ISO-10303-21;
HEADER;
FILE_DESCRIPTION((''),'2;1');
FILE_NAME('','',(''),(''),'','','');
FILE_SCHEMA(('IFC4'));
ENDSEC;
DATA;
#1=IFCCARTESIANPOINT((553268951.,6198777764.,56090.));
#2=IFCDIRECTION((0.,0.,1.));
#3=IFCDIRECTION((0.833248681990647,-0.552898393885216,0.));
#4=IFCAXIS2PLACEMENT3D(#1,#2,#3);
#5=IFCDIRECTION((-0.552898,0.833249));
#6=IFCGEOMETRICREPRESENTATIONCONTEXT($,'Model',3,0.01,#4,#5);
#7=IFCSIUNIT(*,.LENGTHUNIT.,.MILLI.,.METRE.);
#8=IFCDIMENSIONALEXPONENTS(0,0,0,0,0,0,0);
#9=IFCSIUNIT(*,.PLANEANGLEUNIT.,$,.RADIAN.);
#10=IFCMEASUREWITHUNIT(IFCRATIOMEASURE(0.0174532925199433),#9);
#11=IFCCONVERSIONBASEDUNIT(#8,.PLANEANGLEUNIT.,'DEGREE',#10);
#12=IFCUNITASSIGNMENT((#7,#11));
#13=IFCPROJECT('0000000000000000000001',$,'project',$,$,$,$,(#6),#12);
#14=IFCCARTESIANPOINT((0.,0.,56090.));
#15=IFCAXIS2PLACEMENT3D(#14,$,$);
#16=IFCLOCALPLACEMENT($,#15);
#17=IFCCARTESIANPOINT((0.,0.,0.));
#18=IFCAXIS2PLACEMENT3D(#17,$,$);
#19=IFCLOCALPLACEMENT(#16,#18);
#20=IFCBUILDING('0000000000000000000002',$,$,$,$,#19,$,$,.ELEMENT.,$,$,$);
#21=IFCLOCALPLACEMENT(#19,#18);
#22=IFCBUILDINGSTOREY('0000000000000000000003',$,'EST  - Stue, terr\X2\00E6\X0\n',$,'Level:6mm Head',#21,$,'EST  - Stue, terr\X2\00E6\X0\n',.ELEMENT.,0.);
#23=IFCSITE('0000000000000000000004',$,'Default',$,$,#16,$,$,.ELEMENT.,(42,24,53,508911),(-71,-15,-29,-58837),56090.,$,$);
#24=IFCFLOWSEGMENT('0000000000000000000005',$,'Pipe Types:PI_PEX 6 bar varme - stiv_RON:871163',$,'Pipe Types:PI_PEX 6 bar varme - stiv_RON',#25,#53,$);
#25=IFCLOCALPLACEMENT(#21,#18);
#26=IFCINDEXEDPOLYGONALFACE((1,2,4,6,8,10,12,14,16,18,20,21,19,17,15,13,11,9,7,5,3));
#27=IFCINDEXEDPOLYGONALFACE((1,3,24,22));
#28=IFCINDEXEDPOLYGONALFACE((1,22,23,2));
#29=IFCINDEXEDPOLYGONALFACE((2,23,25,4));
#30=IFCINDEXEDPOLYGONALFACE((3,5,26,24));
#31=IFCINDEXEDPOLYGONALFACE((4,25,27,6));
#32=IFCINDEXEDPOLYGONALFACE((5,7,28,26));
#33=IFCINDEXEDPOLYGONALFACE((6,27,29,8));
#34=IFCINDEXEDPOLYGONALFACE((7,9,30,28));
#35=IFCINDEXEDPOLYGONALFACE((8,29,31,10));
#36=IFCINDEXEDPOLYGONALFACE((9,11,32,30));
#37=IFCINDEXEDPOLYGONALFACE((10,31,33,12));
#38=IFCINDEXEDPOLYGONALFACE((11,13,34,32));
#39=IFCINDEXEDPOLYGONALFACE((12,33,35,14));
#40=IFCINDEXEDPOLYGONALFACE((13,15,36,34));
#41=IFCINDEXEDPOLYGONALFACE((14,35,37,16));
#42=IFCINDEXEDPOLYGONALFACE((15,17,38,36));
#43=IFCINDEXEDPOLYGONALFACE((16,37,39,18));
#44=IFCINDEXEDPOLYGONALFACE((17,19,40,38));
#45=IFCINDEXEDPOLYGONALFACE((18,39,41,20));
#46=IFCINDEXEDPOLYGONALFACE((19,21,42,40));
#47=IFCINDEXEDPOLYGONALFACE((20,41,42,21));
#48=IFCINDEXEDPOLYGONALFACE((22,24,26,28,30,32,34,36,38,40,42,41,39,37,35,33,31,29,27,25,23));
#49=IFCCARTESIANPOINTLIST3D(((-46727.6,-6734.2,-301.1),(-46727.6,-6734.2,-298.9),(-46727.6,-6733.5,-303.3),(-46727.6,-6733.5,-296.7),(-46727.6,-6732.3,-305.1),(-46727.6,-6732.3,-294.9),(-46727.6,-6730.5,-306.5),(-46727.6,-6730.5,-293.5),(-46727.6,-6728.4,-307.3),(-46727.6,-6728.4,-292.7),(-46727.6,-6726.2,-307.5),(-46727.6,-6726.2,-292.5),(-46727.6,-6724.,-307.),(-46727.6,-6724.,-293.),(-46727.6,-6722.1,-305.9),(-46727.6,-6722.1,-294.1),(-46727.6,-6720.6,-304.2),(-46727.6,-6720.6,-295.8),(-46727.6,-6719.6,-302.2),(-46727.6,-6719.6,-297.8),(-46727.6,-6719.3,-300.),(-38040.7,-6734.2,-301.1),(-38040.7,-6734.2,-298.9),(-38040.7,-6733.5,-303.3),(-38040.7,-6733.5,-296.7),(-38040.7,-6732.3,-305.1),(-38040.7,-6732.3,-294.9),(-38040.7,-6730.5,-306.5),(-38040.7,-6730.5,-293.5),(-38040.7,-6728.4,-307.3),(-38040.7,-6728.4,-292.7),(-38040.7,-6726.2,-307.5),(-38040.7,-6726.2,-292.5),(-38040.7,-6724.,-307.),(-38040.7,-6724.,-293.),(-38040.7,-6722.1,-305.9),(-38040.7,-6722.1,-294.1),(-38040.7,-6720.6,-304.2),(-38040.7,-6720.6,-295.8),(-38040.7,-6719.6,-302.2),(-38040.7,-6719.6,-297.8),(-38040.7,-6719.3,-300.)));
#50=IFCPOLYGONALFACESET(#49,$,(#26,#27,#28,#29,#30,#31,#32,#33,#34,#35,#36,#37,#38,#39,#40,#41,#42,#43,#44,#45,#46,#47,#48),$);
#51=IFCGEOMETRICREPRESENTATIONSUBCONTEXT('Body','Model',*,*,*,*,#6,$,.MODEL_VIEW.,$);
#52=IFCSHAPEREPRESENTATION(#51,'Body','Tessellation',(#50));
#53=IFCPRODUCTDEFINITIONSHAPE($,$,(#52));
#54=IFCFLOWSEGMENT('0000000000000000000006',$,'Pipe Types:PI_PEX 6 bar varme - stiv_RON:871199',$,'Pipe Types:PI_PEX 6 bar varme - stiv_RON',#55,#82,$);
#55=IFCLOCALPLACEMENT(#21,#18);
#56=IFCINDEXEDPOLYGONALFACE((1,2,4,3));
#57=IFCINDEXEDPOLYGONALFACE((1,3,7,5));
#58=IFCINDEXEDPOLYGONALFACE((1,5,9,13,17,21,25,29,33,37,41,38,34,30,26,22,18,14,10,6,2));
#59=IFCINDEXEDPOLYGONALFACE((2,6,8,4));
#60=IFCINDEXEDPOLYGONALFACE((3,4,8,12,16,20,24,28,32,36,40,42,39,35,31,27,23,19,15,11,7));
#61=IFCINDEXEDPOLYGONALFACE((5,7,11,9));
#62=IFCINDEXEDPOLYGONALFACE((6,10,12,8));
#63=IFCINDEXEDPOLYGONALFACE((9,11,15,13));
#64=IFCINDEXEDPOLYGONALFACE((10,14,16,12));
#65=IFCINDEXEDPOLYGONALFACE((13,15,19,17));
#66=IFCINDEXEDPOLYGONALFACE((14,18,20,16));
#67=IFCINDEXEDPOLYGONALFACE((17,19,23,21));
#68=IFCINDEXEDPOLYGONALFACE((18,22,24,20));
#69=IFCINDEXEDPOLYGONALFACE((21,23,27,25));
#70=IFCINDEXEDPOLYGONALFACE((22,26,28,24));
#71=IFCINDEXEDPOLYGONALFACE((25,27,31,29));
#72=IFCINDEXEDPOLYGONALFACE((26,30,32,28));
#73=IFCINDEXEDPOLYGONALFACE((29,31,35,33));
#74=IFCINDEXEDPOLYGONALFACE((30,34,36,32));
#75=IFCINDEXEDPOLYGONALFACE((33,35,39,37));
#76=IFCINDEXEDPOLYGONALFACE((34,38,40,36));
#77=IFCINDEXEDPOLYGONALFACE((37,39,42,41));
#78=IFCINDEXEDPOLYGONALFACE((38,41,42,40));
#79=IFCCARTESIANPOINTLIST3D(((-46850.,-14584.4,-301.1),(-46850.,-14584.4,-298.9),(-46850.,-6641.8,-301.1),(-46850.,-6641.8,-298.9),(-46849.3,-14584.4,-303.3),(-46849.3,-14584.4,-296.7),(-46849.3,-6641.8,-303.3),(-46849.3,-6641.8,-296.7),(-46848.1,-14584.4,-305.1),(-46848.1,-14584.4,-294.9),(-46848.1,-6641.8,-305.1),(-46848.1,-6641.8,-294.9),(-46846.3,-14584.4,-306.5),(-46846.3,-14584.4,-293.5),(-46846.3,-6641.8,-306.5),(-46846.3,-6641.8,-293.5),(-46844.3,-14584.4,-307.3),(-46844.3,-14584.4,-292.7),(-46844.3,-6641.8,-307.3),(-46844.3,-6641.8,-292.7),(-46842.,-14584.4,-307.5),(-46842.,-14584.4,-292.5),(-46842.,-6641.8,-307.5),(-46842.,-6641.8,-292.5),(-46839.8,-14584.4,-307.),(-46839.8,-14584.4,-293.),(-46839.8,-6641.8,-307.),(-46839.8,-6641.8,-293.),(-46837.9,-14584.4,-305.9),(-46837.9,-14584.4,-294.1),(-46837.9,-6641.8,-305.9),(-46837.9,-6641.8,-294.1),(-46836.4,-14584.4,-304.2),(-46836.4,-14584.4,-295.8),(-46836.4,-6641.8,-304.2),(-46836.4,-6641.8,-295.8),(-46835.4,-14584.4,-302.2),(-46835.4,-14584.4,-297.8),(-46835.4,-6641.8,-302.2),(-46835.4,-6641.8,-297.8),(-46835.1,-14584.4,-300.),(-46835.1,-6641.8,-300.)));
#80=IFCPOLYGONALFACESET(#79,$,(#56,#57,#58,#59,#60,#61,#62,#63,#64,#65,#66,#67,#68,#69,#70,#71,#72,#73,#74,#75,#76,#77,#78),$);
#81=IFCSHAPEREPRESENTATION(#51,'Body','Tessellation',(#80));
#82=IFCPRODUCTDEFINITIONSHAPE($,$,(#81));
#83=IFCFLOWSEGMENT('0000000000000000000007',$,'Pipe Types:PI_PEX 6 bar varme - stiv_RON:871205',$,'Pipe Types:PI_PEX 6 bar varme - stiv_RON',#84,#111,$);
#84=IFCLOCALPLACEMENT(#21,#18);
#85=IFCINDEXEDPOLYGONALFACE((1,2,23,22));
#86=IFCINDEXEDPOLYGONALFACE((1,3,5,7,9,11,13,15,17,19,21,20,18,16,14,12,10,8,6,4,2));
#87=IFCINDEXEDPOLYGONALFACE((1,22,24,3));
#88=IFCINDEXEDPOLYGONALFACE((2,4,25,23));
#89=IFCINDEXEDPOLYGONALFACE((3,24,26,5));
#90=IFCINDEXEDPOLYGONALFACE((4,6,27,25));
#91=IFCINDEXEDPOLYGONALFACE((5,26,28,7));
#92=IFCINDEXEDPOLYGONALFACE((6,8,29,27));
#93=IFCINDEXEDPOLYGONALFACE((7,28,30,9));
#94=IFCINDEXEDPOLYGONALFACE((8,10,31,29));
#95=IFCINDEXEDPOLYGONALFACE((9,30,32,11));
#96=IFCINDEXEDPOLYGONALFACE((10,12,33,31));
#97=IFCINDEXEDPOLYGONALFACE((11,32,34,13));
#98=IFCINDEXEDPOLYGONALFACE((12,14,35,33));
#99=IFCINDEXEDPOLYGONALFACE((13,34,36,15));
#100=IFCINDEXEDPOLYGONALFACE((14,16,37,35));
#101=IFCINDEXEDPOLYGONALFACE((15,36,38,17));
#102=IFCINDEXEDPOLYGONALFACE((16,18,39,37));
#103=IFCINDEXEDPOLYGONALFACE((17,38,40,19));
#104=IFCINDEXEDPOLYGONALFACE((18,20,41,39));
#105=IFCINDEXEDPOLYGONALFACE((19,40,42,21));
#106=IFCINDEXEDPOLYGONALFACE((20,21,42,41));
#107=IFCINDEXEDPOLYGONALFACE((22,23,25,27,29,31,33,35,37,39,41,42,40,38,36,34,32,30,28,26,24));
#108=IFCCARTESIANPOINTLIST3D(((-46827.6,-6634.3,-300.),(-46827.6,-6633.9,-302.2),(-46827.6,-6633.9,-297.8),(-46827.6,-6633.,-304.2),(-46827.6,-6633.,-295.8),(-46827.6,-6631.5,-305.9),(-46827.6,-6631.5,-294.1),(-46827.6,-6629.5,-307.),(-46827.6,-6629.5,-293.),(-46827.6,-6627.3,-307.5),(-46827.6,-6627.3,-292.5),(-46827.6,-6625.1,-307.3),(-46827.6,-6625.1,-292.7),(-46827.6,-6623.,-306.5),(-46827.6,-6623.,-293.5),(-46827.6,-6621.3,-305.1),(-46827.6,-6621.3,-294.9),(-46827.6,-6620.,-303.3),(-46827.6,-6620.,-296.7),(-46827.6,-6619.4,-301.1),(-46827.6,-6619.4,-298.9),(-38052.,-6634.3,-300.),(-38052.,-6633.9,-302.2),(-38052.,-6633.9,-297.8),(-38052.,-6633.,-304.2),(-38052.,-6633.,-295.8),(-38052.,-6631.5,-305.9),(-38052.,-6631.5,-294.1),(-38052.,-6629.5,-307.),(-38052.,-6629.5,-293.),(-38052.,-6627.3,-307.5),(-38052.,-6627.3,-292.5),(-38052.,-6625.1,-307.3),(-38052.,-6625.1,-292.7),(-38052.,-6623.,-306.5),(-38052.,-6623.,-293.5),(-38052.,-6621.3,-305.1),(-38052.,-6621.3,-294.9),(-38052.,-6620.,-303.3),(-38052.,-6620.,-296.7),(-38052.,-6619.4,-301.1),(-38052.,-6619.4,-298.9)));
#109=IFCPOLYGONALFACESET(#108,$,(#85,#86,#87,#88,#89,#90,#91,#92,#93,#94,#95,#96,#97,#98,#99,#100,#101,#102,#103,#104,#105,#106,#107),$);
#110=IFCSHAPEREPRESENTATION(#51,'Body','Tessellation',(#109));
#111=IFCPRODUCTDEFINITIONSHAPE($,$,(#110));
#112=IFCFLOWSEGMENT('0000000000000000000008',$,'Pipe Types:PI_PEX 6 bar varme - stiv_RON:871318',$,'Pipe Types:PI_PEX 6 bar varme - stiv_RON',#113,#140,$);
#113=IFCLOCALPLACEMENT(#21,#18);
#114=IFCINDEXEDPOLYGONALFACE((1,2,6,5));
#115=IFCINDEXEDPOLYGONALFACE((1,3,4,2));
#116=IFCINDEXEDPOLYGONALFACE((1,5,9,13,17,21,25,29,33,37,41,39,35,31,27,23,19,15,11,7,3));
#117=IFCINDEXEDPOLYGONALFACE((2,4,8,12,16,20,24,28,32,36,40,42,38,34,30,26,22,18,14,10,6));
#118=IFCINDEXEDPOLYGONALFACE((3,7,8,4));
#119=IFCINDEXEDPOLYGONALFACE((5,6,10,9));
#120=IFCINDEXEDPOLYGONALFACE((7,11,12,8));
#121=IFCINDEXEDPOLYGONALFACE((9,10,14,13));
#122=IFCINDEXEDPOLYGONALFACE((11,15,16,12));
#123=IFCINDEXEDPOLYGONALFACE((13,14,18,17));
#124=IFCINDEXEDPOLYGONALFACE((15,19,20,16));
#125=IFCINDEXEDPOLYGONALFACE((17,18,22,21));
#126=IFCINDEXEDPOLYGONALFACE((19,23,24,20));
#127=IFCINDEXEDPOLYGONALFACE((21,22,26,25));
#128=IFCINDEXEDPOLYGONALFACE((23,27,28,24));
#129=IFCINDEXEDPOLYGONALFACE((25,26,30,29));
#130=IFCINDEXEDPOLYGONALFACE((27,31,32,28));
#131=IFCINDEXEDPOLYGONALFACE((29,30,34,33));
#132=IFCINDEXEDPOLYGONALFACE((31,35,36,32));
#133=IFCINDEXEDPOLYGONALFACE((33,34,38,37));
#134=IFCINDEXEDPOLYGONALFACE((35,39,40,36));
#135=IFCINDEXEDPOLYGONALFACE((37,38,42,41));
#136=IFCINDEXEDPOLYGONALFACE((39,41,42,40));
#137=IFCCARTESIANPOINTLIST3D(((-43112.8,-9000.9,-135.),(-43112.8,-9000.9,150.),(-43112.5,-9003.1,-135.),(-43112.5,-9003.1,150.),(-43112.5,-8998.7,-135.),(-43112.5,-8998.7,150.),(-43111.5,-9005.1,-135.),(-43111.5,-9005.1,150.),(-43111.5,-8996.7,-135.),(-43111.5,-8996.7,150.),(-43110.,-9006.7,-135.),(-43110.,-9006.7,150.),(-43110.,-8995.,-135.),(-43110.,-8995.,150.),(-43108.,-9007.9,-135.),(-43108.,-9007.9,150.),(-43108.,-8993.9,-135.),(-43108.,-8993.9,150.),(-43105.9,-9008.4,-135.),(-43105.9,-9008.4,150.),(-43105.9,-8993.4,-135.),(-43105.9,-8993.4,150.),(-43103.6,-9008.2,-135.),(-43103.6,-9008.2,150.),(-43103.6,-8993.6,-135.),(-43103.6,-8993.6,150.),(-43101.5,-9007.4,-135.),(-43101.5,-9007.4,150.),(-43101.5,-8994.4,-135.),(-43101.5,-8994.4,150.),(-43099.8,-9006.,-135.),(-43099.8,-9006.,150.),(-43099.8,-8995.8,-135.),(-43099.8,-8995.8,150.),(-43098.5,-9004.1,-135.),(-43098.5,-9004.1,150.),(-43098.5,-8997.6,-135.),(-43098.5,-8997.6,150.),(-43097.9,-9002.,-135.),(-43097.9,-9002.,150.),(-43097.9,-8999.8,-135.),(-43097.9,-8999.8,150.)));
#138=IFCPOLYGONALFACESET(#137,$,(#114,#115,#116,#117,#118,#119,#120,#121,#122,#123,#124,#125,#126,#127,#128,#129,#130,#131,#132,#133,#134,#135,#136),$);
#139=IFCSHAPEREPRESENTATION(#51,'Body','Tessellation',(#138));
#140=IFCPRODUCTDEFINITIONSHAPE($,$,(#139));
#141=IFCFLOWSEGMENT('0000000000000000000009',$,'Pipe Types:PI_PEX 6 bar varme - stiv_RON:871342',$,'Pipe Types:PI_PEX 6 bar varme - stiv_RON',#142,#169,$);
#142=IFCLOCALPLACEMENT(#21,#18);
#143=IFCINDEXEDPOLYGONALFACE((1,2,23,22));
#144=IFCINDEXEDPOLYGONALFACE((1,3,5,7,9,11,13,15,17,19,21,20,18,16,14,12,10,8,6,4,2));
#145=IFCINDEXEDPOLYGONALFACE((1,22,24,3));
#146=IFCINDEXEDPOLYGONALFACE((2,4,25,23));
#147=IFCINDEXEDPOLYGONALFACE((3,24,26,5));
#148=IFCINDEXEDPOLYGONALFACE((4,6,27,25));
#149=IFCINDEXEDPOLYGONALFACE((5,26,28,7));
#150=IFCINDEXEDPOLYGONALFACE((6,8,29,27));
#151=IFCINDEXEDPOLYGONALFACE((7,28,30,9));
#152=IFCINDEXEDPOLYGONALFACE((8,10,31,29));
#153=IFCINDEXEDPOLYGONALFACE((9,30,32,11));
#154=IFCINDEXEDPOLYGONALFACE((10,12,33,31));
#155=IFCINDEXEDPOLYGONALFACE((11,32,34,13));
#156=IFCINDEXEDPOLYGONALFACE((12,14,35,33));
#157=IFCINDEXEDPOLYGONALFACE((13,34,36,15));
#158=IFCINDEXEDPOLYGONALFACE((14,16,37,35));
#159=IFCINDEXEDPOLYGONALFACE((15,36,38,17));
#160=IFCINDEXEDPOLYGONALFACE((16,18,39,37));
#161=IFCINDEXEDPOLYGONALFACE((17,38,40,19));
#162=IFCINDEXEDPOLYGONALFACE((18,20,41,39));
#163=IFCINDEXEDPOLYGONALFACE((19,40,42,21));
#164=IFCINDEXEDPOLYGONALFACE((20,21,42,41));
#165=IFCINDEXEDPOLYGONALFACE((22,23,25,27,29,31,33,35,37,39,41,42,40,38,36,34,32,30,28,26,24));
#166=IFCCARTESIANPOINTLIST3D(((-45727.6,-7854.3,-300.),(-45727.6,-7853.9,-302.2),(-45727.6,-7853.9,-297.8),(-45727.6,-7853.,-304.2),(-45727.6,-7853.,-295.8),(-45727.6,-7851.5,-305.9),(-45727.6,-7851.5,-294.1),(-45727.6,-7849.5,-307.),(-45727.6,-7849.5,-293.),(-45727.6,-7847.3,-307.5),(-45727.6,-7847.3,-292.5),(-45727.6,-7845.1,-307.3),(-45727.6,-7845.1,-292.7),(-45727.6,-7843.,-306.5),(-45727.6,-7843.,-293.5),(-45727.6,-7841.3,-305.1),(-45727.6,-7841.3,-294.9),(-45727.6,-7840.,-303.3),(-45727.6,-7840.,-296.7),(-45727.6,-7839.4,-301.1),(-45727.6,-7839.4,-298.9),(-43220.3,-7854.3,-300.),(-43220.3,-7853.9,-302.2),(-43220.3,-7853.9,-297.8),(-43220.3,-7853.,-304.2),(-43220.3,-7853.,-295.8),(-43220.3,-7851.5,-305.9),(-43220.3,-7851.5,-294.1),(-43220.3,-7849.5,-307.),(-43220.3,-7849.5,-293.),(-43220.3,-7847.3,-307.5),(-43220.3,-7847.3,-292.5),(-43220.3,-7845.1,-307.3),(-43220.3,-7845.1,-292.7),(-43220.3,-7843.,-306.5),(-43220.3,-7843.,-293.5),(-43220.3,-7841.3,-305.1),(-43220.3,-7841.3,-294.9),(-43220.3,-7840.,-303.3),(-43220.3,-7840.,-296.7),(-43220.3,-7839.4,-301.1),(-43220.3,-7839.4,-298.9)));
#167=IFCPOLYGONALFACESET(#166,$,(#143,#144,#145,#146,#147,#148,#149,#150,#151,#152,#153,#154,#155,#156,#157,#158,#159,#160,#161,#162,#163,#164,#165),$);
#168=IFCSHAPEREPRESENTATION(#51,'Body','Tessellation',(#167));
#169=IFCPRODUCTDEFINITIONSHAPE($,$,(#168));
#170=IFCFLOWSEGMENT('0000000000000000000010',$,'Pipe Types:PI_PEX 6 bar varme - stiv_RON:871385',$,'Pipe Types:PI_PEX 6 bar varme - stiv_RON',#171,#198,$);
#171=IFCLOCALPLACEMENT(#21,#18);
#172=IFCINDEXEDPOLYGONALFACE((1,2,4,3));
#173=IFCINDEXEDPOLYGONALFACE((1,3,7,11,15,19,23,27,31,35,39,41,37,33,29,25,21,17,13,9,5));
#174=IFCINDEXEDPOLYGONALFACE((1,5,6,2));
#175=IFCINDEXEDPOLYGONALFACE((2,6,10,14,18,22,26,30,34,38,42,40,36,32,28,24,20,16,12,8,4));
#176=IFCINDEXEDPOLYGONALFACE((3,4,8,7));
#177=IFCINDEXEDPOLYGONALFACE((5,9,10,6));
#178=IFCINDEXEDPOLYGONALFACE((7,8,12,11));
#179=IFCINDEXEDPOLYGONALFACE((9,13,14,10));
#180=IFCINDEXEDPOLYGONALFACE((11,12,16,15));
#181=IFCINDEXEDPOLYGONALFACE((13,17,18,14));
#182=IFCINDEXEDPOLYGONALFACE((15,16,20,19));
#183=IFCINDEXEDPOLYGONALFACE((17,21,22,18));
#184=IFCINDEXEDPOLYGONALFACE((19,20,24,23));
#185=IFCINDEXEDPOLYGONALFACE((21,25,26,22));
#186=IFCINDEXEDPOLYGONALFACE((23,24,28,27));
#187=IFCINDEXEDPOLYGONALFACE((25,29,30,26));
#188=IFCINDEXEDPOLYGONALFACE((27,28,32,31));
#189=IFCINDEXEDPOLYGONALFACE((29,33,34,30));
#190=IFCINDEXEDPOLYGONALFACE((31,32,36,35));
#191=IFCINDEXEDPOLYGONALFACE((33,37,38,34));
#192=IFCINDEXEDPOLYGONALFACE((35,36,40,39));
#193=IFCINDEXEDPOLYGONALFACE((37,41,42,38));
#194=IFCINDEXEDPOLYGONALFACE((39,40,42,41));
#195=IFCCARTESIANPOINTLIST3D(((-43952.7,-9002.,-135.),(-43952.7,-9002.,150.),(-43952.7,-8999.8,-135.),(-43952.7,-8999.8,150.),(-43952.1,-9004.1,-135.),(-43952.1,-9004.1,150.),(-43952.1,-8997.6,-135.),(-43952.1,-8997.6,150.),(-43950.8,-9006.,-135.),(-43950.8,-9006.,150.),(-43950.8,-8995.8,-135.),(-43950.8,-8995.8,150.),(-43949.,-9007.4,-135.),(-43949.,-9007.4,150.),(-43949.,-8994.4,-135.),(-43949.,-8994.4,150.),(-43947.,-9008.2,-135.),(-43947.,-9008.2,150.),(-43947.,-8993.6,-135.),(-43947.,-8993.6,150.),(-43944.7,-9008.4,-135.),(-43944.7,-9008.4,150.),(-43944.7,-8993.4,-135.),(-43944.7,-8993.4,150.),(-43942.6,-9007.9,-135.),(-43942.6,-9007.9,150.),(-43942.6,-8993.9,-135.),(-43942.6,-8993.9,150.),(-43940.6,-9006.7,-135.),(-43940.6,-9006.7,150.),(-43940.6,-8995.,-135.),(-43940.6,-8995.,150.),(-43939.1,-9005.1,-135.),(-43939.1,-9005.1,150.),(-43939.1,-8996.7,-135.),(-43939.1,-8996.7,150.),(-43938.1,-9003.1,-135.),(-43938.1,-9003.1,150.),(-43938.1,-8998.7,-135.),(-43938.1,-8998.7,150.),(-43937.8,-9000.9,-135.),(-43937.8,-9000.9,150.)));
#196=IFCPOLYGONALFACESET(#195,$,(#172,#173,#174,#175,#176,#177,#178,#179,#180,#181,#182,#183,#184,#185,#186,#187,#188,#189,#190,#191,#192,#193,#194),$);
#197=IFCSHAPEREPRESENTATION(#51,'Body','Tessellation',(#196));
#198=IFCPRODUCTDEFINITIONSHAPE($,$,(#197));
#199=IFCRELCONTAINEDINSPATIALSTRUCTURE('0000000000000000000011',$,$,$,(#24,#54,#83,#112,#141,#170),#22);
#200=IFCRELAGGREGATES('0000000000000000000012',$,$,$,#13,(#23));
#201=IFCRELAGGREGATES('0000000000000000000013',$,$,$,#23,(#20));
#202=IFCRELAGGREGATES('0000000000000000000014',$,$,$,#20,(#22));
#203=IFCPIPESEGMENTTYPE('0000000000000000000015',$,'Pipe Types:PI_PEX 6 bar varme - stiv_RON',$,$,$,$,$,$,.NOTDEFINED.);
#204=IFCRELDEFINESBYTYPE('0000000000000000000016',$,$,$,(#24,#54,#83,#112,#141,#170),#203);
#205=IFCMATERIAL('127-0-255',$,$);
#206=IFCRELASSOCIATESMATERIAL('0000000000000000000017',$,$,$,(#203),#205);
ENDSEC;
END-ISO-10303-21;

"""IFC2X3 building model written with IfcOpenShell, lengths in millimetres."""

from ifc_helpers import new_model, entity, si_unit, converted_unit, direction, frame, frame_2d, origin, origin_2d_with_axis, place, context, subcontext, project, spatial, circle, extrude, material, type_object, element, save


model = new_model("IFC2X3")

# Units and contexts
model_context = context("Model", 3, precision=0.01, world=frame((553268951.0, 6198777764.0, 56090.0), z_axis=(0.0, 0.0, 1.0), x_axis=(0.833248681990647, -0.552898393885216, 0.0)), true_north=direction((-0.552898, 0.833249)))
body_context = subcontext(model_context, "Body", "Model", "MODEL_VIEW")
ifc_project = project(units=[si_unit("LENGTHUNIT", "METRE", prefix="MILLI"), converted_unit("PLANEANGLEUNIT", "DEGREE", entity("IfcRatioMeasure", 0.0174532925199433), si_unit("PLANEANGLEUNIT", "RADIAN"), dimensions=[0, 0, 0, 0, 0, 0, 0])], contexts=[model_context])

# Site, building, storey
site_placement = place(None, frame((0.0, 0.0, 56090.0)))
site = spatial("IfcSite", under=ifc_project, at=site_placement, Name="Default", CompositionType="ELEMENT", RefLatitude=(42, 24, 53, 508911), RefLongitude=(-71, -15, -29, -58837), RefElevation=56090.0)
building_placement = place(site_placement, origin())
building = spatial("IfcBuilding", under=site, at=building_placement, CompositionType="ELEMENT")
storey_placement = place(building_placement, frame((0.0, 0.0, 0.0)))
storey = spatial("IfcBuildingStorey", under=building, at=storey_placement, Name="EST  - Stue, terræn", ObjectType="Level:6mm Head", LongName="EST  - Stue, terræn", CompositionType="ELEMENT", Elevation=0.0)

# Flow segments
ifc_material = material(Name="127-0-255")
pipe_segment_type = type_object("IfcPipeSegmentType", Name="Pipe Types:PI_PEX 6 bar varme - stiv_RON", PredefinedType="NOTDEFINED", material=ifc_material)
flow_segment_1_placement = place(storey_placement, origin())
element("IfcFlowSegment", 1, at=flow_segment_1_placement, inside=storey, type_object=pipe_segment_type, Name="Pipe Types:PI_PEX 6 bar varme - stiv_RON:871163", ObjectType="Pipe Types:PI_PEX 6 bar varme - stiv_RON", context=body_context, shape_type="SweptSolid", body=[
    extrude(circle(Radius=7.5, at=frame_2d((0.0, 0.0), x_axis=(1.0, 0.0))), frame((-46727.6, -6726.8, -300.0), z_axis=(1.0, 0.0, 0.0), x_axis=(0.0, 1.0, 0.0)), (0.0, 0.0, 1.0), 8686.9),
])
flow_segment_2_placement = place(storey_placement, origin())
element("IfcFlowSegment", 2, at=flow_segment_2_placement, inside=storey, type_object=pipe_segment_type, Name="Pipe Types:PI_PEX 6 bar varme - stiv_RON:871199", ObjectType="Pipe Types:PI_PEX 6 bar varme - stiv_RON", context=body_context, shape_type="SweptSolid", body=[
    extrude(circle(Radius=7.5, at=origin_2d_with_axis()), frame((-46842.6, -14584.4, -300.0), z_axis=(0.0, 1.0, 0.0), x_axis=(1.0, 0.0, 0.0)), (0.0, 0.0, 1.0), 7942.6),
])
flow_segment_3_placement = place(storey_placement, origin())
element("IfcFlowSegment", 3, at=flow_segment_3_placement, inside=storey, type_object=pipe_segment_type, Name="Pipe Types:PI_PEX 6 bar varme - stiv_RON:871205", ObjectType="Pipe Types:PI_PEX 6 bar varme - stiv_RON", context=body_context, shape_type="SweptSolid", body=[
    extrude(circle(Radius=7.5, at=origin_2d_with_axis()), frame((-46827.6, -6626.8, -300.0), z_axis=(1.0, 0.0, 0.0), x_axis=(0.0, -1.0, 0.0)), (0.0, 0.0, 1.0), 8775.6),
])
flow_segment_4_placement = place(storey_placement, origin())
element("IfcFlowSegment", 4, at=flow_segment_4_placement, inside=storey, type_object=pipe_segment_type, Name="Pipe Types:PI_PEX 6 bar varme - stiv_RON:871318", ObjectType="Pipe Types:PI_PEX 6 bar varme - stiv_RON", context=body_context, shape_type="SweptSolid", body=[
    extrude(circle(Radius=7.5, at=origin_2d_with_axis()), frame((-43105.3, -9000.9, -135.0), z_axis=(0.0, 0.0, 1.0), x_axis=(-1.0, 0.0, 0.0)), (0.0, 0.0, 1.0), 285.0),
])
flow_segment_5_placement = place(storey_placement, origin())
element("IfcFlowSegment", 5, at=flow_segment_5_placement, inside=storey, type_object=pipe_segment_type, Name="Pipe Types:PI_PEX 6 bar varme - stiv_RON:871342", ObjectType="Pipe Types:PI_PEX 6 bar varme - stiv_RON", context=body_context, shape_type="SweptSolid", body=[
    extrude(circle(Radius=7.5, at=origin_2d_with_axis()), frame((-45727.6, -7846.8, -300.0), z_axis=(1.0, 0.0, 0.0), x_axis=(0.0, -1.0, 0.0)), (0.0, 0.0, 1.0), 2507.3),
])
flow_segment_6_placement = place(storey_placement, origin())
element("IfcFlowSegment", 6, at=flow_segment_6_placement, inside=storey, type_object=pipe_segment_type, Name="Pipe Types:PI_PEX 6 bar varme - stiv_RON:871385", ObjectType="Pipe Types:PI_PEX 6 bar varme - stiv_RON", context=body_context, shape_type="SweptSolid", body=[
    extrude(circle(Radius=7.5, at=origin_2d_with_axis()), frame((-43945.3, -9000.9, -135.0)), (0.0, 0.0, 1.0), 285.0),
])

save(model, "model.ifc")
